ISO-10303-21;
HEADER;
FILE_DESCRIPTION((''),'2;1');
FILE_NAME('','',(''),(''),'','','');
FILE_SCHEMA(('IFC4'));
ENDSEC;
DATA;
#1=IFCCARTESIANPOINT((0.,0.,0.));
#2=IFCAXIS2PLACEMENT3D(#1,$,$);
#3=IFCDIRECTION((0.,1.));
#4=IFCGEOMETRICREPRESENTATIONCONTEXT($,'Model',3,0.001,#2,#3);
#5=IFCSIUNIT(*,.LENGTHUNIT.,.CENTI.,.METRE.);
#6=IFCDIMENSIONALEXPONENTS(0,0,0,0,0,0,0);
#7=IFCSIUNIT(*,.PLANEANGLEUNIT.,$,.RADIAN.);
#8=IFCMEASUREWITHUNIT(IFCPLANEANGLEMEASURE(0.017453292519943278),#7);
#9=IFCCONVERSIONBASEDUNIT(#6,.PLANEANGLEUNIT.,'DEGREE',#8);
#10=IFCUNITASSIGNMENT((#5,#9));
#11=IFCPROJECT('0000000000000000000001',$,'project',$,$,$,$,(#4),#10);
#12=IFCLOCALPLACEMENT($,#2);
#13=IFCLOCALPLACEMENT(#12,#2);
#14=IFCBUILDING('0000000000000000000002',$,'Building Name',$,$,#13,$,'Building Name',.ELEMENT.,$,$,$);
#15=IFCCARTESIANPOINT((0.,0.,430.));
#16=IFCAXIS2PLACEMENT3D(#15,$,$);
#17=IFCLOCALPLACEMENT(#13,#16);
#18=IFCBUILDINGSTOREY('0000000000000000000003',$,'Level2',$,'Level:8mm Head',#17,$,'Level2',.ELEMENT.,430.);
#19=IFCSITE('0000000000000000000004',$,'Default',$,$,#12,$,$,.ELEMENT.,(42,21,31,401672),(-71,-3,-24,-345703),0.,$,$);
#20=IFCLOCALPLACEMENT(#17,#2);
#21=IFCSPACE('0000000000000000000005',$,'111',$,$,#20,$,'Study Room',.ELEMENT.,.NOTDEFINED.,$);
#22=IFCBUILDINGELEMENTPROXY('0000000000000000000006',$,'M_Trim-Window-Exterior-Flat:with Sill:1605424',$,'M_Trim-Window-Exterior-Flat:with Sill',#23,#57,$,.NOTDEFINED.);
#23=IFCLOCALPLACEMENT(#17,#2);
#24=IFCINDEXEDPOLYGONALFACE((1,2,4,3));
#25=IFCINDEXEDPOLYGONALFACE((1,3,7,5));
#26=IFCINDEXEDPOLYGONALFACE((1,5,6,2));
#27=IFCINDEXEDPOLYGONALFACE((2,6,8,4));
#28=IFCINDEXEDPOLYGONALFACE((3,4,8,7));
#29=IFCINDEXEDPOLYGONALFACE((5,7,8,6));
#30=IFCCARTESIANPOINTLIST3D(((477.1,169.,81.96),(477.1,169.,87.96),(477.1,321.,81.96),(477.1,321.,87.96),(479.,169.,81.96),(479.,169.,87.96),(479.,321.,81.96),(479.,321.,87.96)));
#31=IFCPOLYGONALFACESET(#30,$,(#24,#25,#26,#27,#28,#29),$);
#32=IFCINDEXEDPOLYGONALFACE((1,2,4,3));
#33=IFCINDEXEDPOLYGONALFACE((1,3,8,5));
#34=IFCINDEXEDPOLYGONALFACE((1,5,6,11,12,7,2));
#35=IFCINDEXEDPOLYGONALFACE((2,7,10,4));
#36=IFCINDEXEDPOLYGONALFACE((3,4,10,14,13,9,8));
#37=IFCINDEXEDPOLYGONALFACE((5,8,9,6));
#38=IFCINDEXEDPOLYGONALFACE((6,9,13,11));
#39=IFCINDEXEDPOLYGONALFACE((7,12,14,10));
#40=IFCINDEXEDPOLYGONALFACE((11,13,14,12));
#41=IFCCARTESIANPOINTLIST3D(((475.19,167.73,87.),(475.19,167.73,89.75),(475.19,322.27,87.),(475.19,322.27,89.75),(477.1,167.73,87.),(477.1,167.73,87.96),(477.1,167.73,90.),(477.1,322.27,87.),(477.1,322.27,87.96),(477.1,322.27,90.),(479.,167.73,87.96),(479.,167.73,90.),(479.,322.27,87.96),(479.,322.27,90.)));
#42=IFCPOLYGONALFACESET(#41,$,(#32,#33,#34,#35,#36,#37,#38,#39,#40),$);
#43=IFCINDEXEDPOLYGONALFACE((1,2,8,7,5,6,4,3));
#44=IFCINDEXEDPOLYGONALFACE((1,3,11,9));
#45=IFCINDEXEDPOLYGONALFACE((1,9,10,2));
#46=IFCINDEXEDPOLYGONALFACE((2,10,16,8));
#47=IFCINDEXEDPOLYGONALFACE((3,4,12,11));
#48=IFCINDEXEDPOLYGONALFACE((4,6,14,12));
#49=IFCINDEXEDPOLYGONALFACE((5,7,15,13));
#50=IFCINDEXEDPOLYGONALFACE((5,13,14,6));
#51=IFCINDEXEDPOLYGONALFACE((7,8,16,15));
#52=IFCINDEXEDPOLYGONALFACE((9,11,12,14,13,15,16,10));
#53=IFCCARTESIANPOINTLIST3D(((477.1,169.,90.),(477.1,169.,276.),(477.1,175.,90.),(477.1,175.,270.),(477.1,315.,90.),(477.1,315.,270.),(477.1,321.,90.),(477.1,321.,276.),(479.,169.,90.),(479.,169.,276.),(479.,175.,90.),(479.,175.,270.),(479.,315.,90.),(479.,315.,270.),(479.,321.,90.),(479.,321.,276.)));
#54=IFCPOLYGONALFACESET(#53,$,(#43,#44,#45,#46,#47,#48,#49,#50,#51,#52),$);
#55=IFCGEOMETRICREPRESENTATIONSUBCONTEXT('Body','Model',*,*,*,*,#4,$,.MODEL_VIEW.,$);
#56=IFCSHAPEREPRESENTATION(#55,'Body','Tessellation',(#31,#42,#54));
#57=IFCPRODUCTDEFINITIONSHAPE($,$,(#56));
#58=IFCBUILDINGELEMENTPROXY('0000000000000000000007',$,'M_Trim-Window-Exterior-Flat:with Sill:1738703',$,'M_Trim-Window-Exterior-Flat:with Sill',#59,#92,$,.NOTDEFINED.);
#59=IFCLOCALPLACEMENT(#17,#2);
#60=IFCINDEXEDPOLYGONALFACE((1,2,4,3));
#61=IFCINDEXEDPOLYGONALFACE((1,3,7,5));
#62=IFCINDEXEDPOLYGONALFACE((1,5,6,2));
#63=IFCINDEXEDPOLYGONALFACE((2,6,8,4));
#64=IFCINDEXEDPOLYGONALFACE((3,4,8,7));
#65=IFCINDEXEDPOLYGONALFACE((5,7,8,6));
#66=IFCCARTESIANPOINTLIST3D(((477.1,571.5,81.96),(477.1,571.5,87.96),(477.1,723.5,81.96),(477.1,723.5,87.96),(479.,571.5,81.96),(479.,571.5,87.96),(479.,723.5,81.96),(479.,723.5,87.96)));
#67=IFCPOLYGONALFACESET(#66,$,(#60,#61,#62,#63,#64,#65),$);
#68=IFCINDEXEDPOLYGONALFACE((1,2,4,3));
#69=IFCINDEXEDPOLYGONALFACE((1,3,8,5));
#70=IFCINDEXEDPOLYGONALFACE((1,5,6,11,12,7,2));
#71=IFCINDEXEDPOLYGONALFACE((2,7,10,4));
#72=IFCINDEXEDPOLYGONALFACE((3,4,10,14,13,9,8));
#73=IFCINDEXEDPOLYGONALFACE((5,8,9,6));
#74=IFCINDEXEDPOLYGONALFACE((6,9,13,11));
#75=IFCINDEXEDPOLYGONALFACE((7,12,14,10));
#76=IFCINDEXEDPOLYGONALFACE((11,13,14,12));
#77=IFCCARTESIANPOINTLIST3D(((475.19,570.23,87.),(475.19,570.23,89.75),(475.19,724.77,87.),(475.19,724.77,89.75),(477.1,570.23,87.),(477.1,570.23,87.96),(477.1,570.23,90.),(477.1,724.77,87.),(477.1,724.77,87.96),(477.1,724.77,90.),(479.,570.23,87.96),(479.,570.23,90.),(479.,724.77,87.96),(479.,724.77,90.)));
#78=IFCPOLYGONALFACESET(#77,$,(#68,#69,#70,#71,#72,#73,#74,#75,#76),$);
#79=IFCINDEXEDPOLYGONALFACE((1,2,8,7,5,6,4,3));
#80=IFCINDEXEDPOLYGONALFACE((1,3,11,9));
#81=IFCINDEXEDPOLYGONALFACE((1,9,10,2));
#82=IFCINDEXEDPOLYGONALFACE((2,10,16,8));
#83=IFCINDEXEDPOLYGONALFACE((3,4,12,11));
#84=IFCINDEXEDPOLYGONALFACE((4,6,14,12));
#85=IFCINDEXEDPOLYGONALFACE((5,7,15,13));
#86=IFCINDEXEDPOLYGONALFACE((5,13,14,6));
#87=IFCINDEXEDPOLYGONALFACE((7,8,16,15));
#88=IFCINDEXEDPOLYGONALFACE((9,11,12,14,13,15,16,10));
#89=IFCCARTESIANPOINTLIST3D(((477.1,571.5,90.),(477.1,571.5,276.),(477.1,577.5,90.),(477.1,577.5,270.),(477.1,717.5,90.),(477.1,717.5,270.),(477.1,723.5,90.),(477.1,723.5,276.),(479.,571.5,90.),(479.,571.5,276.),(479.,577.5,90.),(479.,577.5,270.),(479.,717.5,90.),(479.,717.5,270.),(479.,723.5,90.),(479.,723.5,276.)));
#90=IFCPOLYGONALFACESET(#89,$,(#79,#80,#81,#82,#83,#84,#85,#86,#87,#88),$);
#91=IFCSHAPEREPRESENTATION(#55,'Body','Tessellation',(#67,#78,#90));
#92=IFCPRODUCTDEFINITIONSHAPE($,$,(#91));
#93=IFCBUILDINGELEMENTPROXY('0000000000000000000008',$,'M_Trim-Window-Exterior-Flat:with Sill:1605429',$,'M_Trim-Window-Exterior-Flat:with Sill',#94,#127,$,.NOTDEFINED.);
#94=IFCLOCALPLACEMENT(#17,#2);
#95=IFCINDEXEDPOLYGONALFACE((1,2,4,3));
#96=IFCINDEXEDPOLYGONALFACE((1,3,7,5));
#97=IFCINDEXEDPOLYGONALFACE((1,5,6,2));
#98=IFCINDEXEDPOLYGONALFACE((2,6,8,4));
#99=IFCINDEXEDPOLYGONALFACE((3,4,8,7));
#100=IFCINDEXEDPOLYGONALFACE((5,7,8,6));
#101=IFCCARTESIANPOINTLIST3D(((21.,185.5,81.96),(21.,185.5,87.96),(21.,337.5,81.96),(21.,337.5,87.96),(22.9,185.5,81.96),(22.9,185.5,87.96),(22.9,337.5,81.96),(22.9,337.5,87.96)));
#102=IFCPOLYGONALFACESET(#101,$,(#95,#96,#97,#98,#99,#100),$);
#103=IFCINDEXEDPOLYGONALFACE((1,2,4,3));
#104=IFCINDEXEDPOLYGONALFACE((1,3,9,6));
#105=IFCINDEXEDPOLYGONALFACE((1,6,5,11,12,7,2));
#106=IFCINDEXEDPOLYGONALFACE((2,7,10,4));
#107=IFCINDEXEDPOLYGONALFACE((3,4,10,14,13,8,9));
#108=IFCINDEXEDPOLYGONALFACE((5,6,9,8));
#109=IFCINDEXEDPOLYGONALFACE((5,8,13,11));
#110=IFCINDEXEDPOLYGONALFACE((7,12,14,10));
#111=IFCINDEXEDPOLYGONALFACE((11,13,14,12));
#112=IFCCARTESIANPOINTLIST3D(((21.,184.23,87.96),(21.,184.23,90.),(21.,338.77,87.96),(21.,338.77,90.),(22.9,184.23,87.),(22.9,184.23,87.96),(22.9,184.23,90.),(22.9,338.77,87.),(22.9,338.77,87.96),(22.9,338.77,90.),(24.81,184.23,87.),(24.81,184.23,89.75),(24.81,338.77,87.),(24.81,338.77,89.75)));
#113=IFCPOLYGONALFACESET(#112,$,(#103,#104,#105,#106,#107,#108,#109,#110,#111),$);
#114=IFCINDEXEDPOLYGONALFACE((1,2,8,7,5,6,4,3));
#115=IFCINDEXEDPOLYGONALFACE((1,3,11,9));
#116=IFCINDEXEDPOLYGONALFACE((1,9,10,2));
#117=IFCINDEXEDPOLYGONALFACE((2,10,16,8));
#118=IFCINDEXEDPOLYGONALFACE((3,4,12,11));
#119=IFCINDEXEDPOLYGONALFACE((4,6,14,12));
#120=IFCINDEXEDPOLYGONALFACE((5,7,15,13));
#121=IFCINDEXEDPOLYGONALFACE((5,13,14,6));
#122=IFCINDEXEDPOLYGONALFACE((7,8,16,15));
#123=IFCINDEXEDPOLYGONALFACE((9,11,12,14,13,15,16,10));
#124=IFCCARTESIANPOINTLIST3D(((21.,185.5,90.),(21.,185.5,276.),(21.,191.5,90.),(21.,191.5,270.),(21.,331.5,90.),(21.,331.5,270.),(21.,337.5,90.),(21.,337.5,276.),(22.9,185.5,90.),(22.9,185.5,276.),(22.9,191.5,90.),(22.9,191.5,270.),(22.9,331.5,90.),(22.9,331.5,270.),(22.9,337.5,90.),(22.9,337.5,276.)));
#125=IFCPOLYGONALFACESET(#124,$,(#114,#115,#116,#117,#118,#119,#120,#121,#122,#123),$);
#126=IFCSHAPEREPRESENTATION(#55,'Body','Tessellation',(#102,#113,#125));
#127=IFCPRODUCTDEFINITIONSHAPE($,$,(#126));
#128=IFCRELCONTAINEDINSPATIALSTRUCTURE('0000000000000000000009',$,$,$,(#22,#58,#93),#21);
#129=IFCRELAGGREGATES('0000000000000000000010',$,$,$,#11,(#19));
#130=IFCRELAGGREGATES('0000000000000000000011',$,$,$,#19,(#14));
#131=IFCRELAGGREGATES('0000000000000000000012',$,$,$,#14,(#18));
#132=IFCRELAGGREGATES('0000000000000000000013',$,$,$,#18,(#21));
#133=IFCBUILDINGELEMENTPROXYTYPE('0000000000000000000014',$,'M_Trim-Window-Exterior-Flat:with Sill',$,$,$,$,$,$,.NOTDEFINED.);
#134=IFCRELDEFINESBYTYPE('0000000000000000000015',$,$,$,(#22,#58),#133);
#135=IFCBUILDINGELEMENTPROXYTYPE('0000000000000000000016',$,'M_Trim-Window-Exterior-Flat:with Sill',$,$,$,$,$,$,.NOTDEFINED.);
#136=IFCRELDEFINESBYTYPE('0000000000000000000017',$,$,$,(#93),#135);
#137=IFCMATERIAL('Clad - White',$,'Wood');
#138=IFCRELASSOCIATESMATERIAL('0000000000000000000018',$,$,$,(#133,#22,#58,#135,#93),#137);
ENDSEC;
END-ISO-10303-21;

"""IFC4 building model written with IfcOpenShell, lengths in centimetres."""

from ifc_helpers import new_model, entity, si_unit, converted_unit, direction, frame, origin, place, context, subcontext, project, spatial, indexed_curve, outline, extrude, source, transform, mapped, material, type_object, type_shapes, element, save


model = new_model("IFC4")

# Units and contexts
model_context = context("Model", 3, precision=0.001, world=origin(), true_north=direction((0.0, 1.0)))
body_context = subcontext(model_context, "Body", "Model", "MODEL_VIEW")
ifc_project = project(units=[si_unit("LENGTHUNIT", "METRE", prefix="CENTI"), converted_unit("PLANEANGLEUNIT", "DEGREE", entity("IfcPlaneAngleMeasure", 0.017453292519943278), si_unit("PLANEANGLEUNIT", "RADIAN"), dimensions=[0, 0, 0, 0, 0, 0, 0])], contexts=[model_context])

# Site, building, storey
site_placement = place(None, origin())
site = spatial("IfcSite", under=ifc_project, at=site_placement, Name="Default", CompositionType="ELEMENT", RefLatitude=(42, 21, 31, 401672), RefLongitude=(-71, -3, -24, -345703), RefElevation=0.0)
building_placement = place(site_placement, origin())
building = spatial("IfcBuilding", under=site, at=building_placement, Name="Building Name", LongName="Building Name", CompositionType="ELEMENT")
storey_placement = place(building_placement, frame((0.0, 0.0, 430.0)))
storey = spatial("IfcBuildingStorey", under=building, at=storey_placement, Name="Level2", ObjectType="Level:8mm Head", LongName="Level2", CompositionType="ELEMENT", Elevation=430.0)

# Shared definitions
space_placement = place(storey_placement, origin())
space = spatial("IfcSpace", under=storey, at=space_placement, Name="111", LongName="Study Room", CompositionType="ELEMENT", PredefinedType="NOTDEFINED")

# Building element proxies
ifc_material_1 = material(Name="Clad - White", Category="Wood")
building_element_proxy_type_1 = type_object("IfcBuildingElementProxyType", Name="M_Trim-Window-Exterior-Flat:with Sill", PredefinedType="NOTDEFINED", material=ifc_material_1)
shared_shape_1 = source(origin(), body_context, "Body", "SweptSolid", [
    extrude(outline(indexed_curve([(-3.0, -76.0), (3.0, -76.0), (3.0, 76.0), (-3.0, 76.0), (-3.0, -76.0)], self_intersect=False)), frame((0.0, 185.04, 0.0), z_axis=(0.0, 0.0, 1.0), x_axis=(0.0, 1.0, 0.0)), (0.0, 0.0, 1.0), 1.9),
    extrude(outline(indexed_curve([(-1.52, -1.9), (1.23, -1.9), (1.48, 0.0), (1.48, 1.9), (-0.57, 1.9), (-0.57, 0.0), (-1.52, 0.0), (-1.52, -1.9)], self_intersect=False)), frame((-77.27, 181.48, 1.9), z_axis=(1.0, 0.0, 0.0), x_axis=(0.0, -1.0, 0.0)), (0.0, 0.0, 1.0), 154.54),
    extrude(outline(indexed_curve([(-76.0, -94.5), (76.0, -94.5), (76.0, 91.5), (70.0, 91.5), (70.0, -88.5), (-70.0, -88.5), (-70.0, 91.5), (-76.0, 91.5), (-76.0, -94.5)], self_intersect=False)), frame((0.0, 88.5, 0.0)), (0.0, 0.0, 1.0), 1.9),
])
type_shapes(building_element_proxy_type_1, [shared_shape_1])
for number, where, z_axis, x_axis, name in (
    (1, (479.0, 245.0, 270.0), (-1.0, 0.0, 0.0), (0.0, 1.0, 0.0), "M_Trim-Window-Exterior-Flat:with Sill:1605424"),
    (2, (479.0, 647.5, 270.0), (-1.0, 0.0, 0.0), (0.0, 1.0, 0.0), "M_Trim-Window-Exterior-Flat:with Sill:1738703"),
):
    element("IfcBuildingElementProxy", number, at=place(space_placement, frame(where, z_axis=z_axis, x_axis=x_axis)), inside=space, type_object=building_element_proxy_type_1, material=ifc_material_1, Name=name, ObjectType="M_Trim-Window-Exterior-Flat:with Sill", PredefinedType="NOTDEFINED", context=body_context, shape_type="MappedRepresentation", body=[
        mapped(shared_shape_1, transform((0.0, 0.0, 0.0), scale=1.0)),
    ])
building_element_proxy_type_2 = type_object("IfcBuildingElementProxyType", Name="M_Trim-Window-Exterior-Flat:with Sill", PredefinedType="NOTDEFINED", material=ifc_material_1)
shared_shape_2 = source(origin(), body_context, "Body", "SweptSolid", [
    extrude(outline(indexed_curve([(-76.0, -3.0), (76.0, -3.0), (76.0, 3.0), (-76.0, 3.0), (-76.0, -3.0)], self_intersect=False)), frame((0.0, -185.04, 0.0), z_axis=(0.0, 0.0, 1.0), x_axis=(-1.0, 0.0, 0.0)), (0.0, 0.0, 1.0), 1.9),
    extrude(outline(indexed_curve([(-1.9, -1.52), (0.0, -1.52), (0.0, -0.57), (1.9, -0.57), (1.9, 1.48), (0.0, 1.48), (-1.9, 1.23), (-1.9, -1.52)], self_intersect=False)), frame((-77.27, -181.48, 1.9), z_axis=(1.0, 0.0, 0.0), x_axis=(0.0, 0.0, -1.0)), (0.0, 0.0, 1.0), 154.54),
    extrude(outline(indexed_curve([(-94.5, -76.0), (91.5, -76.0), (91.5, -70.0), (-88.5, -70.0), (-88.5, 70.0), (91.5, 70.0), (91.5, 76.0), (-94.5, 76.0), (-94.5, -76.0)], self_intersect=False)), frame((0.0, -88.5, 0.0), z_axis=(0.0, 0.0, 1.0), x_axis=(0.0, -1.0, 0.0)), (0.0, 0.0, 1.0), 1.9),
])
type_shapes(building_element_proxy_type_2, [shared_shape_2])
proxy_1_placement = place(space_placement, frame((21.0, 261.5, 270.0), z_axis=(1.0, 0.0, 0.0), x_axis=(0.0, 1.0, 0.0)))
element("IfcBuildingElementProxy", 3, at=proxy_1_placement, inside=space, type_object=building_element_proxy_type_2, material=ifc_material_1, Name="M_Trim-Window-Exterior-Flat:with Sill:1605429", ObjectType="M_Trim-Window-Exterior-Flat:with Sill", PredefinedType="NOTDEFINED", context=body_context, shape_type="MappedRepresentation", body=[
    mapped(shared_shape_2, transform((0.0, 0.0, 0.0), scale=1.0)),
])

save(model, "model.ifc")
